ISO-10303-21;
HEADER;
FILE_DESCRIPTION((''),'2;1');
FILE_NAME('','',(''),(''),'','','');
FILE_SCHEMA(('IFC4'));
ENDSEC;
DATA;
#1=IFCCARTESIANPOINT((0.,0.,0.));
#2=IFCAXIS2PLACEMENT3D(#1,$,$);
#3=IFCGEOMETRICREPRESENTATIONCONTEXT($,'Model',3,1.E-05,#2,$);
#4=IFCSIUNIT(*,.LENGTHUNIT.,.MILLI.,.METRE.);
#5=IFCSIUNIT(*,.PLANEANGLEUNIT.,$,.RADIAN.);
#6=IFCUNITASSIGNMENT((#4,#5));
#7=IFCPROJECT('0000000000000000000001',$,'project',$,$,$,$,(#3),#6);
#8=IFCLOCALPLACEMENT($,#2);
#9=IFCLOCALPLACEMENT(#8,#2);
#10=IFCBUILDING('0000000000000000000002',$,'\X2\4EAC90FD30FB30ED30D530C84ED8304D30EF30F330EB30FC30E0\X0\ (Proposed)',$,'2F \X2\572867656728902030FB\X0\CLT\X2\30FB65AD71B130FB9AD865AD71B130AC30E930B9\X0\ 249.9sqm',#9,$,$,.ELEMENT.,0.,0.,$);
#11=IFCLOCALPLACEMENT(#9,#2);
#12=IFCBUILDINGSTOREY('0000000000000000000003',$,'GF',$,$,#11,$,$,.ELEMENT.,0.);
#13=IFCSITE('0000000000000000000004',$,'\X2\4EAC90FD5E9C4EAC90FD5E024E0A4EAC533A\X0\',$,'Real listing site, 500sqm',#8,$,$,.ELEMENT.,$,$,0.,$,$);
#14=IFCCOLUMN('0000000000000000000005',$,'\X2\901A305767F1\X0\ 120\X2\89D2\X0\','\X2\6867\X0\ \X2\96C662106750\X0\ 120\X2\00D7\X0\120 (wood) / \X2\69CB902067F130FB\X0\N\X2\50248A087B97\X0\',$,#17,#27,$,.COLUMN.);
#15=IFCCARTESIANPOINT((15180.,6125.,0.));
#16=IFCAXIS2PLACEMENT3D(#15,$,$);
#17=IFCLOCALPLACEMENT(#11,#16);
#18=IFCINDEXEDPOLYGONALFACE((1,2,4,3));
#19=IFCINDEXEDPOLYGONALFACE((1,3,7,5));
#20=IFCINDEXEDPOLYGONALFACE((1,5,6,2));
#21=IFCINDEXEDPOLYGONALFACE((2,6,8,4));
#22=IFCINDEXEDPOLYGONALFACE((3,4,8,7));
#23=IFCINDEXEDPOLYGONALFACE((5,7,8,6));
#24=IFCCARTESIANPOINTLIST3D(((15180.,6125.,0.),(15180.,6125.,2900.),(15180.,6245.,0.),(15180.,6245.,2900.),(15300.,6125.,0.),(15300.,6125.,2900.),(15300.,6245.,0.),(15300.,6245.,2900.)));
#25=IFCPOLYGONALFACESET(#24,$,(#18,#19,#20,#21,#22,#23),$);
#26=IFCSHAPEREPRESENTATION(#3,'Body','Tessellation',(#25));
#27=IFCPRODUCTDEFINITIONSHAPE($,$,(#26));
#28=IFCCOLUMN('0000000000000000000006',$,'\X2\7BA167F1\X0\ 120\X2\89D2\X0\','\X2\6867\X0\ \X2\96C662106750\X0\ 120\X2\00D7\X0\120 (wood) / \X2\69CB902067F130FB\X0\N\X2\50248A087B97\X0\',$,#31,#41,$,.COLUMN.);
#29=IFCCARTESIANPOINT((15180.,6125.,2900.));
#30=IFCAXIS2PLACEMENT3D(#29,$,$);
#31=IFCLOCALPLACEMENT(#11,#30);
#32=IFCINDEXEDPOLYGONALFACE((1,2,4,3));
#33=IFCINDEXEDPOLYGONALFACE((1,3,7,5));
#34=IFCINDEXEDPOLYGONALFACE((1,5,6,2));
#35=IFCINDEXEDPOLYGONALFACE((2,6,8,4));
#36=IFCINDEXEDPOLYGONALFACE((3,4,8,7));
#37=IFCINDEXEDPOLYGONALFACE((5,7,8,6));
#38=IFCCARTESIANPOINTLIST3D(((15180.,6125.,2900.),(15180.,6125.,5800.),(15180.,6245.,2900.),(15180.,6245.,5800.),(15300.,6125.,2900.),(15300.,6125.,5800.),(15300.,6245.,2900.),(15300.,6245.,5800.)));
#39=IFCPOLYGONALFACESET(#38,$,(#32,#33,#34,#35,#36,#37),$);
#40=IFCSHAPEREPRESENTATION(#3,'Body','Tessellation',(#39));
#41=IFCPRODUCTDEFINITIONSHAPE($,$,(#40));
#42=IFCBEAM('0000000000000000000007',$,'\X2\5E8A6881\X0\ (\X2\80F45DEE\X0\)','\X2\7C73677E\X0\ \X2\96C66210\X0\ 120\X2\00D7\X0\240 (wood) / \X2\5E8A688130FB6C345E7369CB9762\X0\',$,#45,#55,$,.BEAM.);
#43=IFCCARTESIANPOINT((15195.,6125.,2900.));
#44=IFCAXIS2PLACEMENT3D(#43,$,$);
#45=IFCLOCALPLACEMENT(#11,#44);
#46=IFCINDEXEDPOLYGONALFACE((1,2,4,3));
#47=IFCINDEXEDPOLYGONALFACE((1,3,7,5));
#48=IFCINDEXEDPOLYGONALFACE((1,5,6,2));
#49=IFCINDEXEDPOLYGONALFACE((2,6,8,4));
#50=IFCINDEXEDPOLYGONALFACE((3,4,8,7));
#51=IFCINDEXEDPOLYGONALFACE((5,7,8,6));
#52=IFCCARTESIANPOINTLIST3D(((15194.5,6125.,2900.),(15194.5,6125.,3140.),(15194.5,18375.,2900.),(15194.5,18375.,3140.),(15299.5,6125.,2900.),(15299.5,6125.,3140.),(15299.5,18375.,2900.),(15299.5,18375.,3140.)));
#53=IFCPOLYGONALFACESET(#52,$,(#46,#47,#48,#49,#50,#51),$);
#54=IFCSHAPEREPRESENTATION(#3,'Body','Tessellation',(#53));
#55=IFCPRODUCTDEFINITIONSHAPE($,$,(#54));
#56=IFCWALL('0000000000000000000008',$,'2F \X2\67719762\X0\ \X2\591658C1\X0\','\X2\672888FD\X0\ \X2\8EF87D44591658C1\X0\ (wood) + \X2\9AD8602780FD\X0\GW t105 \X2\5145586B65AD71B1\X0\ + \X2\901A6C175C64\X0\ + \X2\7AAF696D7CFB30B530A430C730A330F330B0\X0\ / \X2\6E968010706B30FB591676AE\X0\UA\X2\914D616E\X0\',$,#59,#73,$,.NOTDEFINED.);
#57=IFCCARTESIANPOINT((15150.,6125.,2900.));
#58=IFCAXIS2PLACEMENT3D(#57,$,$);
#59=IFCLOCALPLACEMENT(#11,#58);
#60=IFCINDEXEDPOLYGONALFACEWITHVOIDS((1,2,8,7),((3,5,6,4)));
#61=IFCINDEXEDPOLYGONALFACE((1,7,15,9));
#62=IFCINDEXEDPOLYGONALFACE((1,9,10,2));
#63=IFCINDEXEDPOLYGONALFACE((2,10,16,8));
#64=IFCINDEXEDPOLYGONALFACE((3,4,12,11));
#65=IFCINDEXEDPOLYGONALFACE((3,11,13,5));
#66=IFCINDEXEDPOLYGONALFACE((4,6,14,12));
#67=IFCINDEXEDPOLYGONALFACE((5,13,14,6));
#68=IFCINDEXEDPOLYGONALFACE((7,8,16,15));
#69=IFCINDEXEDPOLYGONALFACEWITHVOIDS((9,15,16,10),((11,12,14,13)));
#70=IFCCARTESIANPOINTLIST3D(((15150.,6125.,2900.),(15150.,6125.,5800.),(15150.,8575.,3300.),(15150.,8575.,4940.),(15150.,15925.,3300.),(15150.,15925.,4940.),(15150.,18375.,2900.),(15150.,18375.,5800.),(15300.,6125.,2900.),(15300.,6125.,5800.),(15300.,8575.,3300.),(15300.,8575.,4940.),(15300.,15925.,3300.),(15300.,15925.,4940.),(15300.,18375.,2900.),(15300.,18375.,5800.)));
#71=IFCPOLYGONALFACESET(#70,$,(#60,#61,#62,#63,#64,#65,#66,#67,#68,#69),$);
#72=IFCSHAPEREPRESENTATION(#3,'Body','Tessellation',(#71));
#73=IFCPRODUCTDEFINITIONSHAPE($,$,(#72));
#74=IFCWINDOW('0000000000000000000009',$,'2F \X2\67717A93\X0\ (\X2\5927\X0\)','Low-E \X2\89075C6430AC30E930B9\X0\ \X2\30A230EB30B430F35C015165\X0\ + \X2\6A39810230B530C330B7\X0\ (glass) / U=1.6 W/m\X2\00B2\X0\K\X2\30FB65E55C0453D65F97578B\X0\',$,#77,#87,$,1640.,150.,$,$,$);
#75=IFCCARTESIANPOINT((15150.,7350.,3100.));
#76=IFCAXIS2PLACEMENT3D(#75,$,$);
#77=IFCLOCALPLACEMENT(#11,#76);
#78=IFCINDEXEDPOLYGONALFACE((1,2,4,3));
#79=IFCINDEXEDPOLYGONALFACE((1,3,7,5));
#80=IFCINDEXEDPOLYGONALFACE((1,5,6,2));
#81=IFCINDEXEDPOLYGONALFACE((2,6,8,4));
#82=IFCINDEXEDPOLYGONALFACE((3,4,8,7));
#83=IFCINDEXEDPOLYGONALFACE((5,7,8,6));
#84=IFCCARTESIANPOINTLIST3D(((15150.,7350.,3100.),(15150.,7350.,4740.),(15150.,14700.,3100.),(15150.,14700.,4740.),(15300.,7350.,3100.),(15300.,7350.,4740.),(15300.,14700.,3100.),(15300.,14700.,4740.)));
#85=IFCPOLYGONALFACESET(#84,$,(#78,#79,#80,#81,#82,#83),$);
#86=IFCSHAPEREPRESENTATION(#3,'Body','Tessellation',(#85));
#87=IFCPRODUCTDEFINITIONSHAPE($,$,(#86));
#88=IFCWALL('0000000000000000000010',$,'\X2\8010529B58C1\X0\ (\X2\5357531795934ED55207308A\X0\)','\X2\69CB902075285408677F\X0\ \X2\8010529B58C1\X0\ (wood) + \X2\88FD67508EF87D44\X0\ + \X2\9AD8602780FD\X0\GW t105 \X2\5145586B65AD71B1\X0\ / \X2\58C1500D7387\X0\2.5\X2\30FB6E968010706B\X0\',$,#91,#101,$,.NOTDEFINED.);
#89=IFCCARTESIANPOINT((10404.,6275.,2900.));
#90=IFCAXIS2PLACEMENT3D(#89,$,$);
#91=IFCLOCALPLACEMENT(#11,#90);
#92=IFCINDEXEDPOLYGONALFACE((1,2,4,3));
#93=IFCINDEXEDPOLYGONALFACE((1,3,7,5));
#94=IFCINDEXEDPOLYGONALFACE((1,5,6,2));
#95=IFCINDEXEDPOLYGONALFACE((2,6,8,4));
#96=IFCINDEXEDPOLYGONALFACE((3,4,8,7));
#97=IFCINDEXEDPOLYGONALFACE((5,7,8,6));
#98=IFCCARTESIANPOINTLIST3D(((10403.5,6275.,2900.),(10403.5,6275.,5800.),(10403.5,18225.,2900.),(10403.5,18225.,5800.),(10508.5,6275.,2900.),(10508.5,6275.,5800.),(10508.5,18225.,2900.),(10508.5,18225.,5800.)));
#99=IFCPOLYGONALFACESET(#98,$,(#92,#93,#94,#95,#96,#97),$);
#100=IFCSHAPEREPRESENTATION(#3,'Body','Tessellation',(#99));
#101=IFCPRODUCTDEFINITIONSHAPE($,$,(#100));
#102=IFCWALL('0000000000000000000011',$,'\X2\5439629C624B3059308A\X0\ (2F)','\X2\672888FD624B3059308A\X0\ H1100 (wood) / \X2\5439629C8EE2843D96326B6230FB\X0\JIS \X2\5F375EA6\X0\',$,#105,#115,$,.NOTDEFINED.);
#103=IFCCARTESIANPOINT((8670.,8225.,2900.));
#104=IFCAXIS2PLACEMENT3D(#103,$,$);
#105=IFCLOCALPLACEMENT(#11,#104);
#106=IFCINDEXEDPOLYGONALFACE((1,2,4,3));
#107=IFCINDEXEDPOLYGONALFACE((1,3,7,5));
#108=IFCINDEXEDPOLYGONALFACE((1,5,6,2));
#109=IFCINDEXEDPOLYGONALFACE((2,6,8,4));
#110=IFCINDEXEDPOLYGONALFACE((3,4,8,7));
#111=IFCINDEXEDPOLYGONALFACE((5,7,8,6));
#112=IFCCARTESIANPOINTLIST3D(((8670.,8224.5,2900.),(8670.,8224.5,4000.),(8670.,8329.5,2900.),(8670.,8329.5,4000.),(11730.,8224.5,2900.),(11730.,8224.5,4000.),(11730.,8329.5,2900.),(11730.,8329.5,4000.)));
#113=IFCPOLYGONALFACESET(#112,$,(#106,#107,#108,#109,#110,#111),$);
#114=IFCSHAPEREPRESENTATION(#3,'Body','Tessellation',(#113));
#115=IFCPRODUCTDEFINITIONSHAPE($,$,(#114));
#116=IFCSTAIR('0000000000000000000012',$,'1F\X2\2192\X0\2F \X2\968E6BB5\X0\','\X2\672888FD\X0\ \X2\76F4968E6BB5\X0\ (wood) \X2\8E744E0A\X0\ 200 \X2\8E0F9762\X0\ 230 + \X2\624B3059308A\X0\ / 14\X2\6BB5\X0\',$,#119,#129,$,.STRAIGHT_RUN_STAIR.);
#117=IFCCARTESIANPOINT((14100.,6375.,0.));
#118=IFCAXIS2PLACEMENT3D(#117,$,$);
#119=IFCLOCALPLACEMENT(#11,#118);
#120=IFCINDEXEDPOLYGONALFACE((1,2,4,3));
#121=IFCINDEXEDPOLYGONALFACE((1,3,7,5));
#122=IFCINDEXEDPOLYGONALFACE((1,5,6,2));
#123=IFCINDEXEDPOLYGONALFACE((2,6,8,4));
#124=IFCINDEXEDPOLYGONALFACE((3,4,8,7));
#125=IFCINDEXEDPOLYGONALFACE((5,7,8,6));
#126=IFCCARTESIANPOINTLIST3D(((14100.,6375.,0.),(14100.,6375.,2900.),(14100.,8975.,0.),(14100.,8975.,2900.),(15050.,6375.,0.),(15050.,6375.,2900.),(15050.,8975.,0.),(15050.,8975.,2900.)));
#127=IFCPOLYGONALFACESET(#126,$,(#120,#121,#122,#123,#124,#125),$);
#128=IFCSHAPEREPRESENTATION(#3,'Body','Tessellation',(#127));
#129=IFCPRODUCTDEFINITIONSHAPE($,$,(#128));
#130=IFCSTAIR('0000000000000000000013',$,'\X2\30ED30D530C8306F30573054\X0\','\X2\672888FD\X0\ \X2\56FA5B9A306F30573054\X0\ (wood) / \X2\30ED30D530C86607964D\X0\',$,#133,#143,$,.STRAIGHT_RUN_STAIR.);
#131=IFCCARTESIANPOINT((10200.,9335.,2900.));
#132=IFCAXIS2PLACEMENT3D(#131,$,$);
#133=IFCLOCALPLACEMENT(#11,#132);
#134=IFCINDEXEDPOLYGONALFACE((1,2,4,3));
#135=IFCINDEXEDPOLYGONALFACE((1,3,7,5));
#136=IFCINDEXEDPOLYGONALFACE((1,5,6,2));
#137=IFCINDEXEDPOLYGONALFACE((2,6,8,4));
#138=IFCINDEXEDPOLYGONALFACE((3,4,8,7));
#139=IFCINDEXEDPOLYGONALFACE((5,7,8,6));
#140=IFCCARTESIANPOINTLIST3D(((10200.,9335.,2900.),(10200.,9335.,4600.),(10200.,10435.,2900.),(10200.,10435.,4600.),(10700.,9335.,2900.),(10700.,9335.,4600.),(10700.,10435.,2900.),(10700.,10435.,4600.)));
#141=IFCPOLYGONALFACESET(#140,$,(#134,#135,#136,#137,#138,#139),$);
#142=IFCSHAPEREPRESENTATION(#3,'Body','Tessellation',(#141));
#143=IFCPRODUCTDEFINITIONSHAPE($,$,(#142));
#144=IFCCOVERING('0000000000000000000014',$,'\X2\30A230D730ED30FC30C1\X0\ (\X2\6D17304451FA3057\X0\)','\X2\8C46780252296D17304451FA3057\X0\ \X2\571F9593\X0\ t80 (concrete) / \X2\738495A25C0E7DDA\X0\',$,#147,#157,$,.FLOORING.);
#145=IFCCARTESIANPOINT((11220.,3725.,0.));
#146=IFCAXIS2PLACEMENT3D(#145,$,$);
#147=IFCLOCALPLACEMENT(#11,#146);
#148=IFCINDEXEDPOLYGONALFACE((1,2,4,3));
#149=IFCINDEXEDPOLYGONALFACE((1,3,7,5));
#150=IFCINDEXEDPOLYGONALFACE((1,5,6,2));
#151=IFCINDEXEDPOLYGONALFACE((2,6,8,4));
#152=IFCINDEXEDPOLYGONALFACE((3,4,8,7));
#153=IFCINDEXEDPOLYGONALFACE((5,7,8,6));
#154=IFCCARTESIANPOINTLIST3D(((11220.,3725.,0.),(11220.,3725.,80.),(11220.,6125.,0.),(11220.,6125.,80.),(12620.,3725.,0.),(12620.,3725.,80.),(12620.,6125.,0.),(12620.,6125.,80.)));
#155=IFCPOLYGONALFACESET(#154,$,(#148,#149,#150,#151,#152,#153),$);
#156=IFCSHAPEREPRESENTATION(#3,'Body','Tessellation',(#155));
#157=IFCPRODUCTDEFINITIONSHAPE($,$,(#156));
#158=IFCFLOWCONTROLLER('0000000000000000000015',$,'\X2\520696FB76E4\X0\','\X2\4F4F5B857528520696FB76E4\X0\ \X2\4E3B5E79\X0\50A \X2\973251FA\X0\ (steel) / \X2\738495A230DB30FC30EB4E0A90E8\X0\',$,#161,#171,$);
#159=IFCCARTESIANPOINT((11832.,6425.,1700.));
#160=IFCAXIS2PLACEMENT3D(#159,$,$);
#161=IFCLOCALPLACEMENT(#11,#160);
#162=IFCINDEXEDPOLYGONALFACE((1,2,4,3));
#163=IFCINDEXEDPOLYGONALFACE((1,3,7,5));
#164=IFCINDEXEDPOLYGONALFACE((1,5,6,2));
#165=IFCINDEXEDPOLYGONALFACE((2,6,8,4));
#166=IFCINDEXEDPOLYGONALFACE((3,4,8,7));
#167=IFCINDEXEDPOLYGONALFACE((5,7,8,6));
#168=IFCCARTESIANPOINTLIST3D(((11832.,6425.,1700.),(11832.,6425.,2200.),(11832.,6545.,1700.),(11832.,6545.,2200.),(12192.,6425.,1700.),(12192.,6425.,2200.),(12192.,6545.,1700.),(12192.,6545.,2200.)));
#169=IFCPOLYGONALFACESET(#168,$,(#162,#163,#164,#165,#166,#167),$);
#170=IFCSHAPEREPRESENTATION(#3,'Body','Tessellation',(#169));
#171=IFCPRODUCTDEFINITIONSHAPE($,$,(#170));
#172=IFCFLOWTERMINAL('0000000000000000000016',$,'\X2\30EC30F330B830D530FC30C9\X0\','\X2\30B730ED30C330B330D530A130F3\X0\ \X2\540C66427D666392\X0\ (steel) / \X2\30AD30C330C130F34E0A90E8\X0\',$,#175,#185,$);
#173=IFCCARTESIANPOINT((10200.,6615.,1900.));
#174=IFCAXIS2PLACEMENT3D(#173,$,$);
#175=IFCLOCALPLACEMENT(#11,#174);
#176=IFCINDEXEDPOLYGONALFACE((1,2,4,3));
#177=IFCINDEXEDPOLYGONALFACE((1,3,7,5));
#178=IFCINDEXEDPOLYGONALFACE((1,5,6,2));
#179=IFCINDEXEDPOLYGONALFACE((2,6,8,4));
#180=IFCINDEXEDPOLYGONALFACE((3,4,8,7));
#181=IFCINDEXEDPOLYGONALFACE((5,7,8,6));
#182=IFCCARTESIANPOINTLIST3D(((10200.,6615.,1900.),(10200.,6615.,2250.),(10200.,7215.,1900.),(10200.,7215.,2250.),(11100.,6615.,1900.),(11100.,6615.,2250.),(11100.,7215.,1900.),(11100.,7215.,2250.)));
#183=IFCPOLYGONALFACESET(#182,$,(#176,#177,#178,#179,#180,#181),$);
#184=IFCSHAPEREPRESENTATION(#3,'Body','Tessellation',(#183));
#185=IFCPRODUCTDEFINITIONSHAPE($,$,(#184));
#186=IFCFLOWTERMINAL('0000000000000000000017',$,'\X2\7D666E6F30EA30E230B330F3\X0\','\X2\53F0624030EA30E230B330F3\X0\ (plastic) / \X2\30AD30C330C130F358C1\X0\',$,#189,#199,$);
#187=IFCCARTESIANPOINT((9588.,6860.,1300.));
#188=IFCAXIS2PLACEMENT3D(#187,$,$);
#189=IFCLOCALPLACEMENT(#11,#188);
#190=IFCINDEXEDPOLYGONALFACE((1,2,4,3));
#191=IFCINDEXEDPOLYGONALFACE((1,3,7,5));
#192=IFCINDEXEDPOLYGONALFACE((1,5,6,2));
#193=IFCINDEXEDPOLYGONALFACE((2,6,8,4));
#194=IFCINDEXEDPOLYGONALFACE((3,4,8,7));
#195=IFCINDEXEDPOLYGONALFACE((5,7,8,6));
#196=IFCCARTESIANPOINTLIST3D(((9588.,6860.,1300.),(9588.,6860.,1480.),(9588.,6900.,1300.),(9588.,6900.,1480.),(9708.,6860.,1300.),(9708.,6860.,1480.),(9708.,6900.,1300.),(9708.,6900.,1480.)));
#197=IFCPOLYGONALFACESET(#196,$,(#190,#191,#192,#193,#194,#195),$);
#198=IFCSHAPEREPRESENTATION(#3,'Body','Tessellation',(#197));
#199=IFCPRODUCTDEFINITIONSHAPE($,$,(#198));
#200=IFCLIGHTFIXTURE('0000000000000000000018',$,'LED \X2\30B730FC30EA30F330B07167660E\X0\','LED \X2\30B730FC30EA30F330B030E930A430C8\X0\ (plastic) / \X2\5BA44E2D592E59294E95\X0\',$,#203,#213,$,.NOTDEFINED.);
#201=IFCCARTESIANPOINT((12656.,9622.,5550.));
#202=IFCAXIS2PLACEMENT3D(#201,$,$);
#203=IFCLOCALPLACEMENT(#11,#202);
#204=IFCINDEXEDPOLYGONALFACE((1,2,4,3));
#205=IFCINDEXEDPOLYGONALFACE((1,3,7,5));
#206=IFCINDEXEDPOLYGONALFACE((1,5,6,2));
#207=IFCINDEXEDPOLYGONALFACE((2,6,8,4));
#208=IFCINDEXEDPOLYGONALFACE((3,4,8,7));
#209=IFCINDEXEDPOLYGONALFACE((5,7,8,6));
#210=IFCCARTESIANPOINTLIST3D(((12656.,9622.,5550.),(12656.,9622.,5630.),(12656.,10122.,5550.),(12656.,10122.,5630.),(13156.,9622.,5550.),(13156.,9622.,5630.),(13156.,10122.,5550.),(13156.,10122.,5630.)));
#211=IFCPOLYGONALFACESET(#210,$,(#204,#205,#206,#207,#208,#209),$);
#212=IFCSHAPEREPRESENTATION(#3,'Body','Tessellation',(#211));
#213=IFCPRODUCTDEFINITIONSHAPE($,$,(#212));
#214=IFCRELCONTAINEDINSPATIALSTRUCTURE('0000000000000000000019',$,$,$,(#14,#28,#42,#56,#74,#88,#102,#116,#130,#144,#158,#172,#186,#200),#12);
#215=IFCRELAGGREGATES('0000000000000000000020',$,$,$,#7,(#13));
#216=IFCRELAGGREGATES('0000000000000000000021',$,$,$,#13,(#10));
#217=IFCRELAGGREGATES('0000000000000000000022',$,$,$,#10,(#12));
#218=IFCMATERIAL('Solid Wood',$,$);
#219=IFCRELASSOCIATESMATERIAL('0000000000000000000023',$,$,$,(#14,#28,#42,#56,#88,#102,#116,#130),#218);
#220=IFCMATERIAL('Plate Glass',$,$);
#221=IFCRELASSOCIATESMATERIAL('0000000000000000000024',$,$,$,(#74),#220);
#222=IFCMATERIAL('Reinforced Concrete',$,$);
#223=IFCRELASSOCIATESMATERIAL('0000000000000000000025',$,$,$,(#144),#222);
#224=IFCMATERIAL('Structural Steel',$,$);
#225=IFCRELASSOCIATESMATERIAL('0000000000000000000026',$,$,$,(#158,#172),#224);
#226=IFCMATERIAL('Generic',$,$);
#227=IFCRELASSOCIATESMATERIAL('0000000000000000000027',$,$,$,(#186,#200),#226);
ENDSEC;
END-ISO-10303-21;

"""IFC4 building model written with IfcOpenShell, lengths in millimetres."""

from ifc_helpers import new_model, si_unit, frame, frame_2d, origin, place, context, project, spatial, rectangle, extrude, material, element, fill, save


model = new_model("IFC4")

# Units and contexts
model_context = context("Model", 3, precision=1e-05, world=origin())
ifc_project = project(units=[si_unit("LENGTHUNIT", "METRE", prefix="MILLI"), si_unit("PLANEANGLEUNIT", "RADIAN")], contexts=[model_context])

# Site, building, storey
site_placement = place(None, origin())
site = spatial("IfcSite", under=ifc_project, at=site_placement, Name="京都府京都市上京区", ObjectType="Real listing site, 500sqm", CompositionType="ELEMENT", RefElevation=0.0)
building_placement = place(site_placement, origin())
building = spatial("IfcBuilding", under=site, at=building_placement, Name="京都・ロフト付きワンルーム (Proposed)", ObjectType="2F 在来木造・CLT・断熱・高断熱ガラス 249.9sqm", CompositionType="ELEMENT", ElevationOfRefHeight=0.0, ElevationOfTerrain=0.0)
storey_placement = place(building_placement, origin())
storey = spatial("IfcBuildingStorey", under=building, at=storey_placement, Name="GF", CompositionType="ELEMENT", Elevation=0.0)

# Columns
ifc_material_1 = material(Name="Solid Wood")
column_1_placement = place(storey_placement, frame((15180.0, 6125.0, 0.0)))
element("IfcColumn", 1, at=column_1_placement, inside=storey, material=ifc_material_1, Name="通し柱 120角", Description="桧 集成材 120×120 (wood) / 構造柱・N値計算", PredefinedType="COLUMN", context=model_context, shape_type="SweptSolid", body=[
    extrude(rectangle(XDim=120.0, YDim=120.0, at=frame_2d((60.0, 60.0))), frame((15180.0, 6125.0, 0.0)), (0.0, 0.0, 1.0), 2900.0),
])
column_2_placement = place(storey_placement, frame((15180.0, 6125.0, 2900.0)))
element("IfcColumn", 2, at=column_2_placement, inside=storey, material=ifc_material_1, Name="管柱 120角", Description="桧 集成材 120×120 (wood) / 構造柱・N値計算", PredefinedType="COLUMN", context=model_context, shape_type="SweptSolid", body=[
    extrude(rectangle(XDim=120.0, YDim=120.0, at=frame_2d((60.0, 60.0))), frame((15180.0, 6125.0, 2900.0)), (0.0, 0.0, 1.0), 2900.0),
])

# Beam
beam_1_placement = place(storey_placement, frame((15195.0, 6125.0, 2900.0)))
element("IfcBeam", 3, at=beam_1_placement, inside=storey, material=ifc_material_1, Name="床梁 (胴差)", Description="米松 集成 120×240 (wood) / 床梁・水平構面", PredefinedType="BEAM", context=model_context, shape_type="SweptSolid", body=[
    extrude(rectangle(XDim=105.0, YDim=12250.0, at=frame_2d((52.0, 6125.0))), frame((15195.0, 6125.0, 2900.0)), (0.0, 0.0, 1.0), 240.0),
])

# Shared definitions
ifc_material_2 = material(Name="Plate Glass")

# Wall, opening, window
wall_1_placement = place(storey_placement, frame((15150.0, 6125.0, 2900.0)))
wall_1 = element("IfcWall", 4, at=wall_1_placement, inside=storey, material=ifc_material_1, Name="2F 東面 外壁", Description="木製 軸組外壁 (wood) + 高性能GW t105 充填断熱 + 通気層 + 窯業系サイディング / 準耐火・外皮UA配慮", PredefinedType="NOTDEFINED", context=model_context, shape_type="SweptSolid", body=[
    extrude(rectangle(XDim=150.0, YDim=12250.0, at=frame_2d((75.0, 6125.0))), frame((15150.0, 6125.0, 2900.0)), (0.0, 0.0, 1.0), 2900.0),
])
opening_1_placement = place(storey_placement, frame((15150.0, 7350.0, 3100.0)))
opening_1 = element("IfcOpeningElement", 5, at=opening_1_placement, cuts=wall_1, PredefinedType="NOTDEFINED", context=model_context, shape_type="SweptSolid", body=[
    extrude(rectangle(XDim=150.0, YDim=7350.0, at=frame_2d((75.0, 3675.0))), frame((15150.0, 7350.0, 3100.0)), (0.0, 0.0, 1.0), 1640.0),
])
window_1_placement = place(storey_placement, frame((15150.0, 7350.0, 3100.0)))
window_1 = element("IfcWindow", 6, at=window_1_placement, inside=storey, material=ifc_material_2, Name="2F 東窓 (大)", Description="Low-E 複層ガラス アルゴン封入 + 樹脂サッシ (glass) / U=1.6 W/m²K・日射取得型", OverallHeight=1640.0, OverallWidth=150.0, context=model_context, shape_type="SweptSolid", body=[
    extrude(rectangle(XDim=150.0, YDim=7350.0, at=frame_2d((75.0, 3675.0))), frame((15150.0, 7350.0, 3100.0)), (0.0, 0.0, 1.0), 1640.0),
])
fill(opening_1, window_1)

# Walls
wall_2_placement = place(storey_placement, frame((10404.0, 6275.0, 2900.0)))
element("IfcWall", 7, at=wall_2_placement, inside=storey, material=ifc_material_1, Name="耐力壁 (南北間仕切り)", Description="構造用合板 耐力壁 (wood) + 製材軸組 + 高性能GW t105 充填断熱 / 壁倍率2.5・準耐火", PredefinedType="NOTDEFINED", context=model_context, shape_type="SweptSolid", body=[
    extrude(rectangle(XDim=105.0, YDim=11950.0, at=frame_2d((52.0, 5975.0))), frame((10404.0, 6275.0, 2900.0)), (0.0, 0.0, 1.0), 2900.0),
])
wall_3_placement = place(storey_placement, frame((8670.0, 8225.0, 2900.0)))
element("IfcWall", 8, at=wall_3_placement, inside=storey, material=ifc_material_1, Name="吹抜手すり (2F)", Description="木製手すり H1100 (wood) / 吹抜転落防止・JIS 強度", PredefinedType="NOTDEFINED", context=model_context, shape_type="SweptSolid", body=[
    extrude(rectangle(XDim=3060.0, YDim=105.0, at=frame_2d((1530.0, 52.0))), frame((8670.0, 8225.0, 2900.0)), (0.0, 0.0, 1.0), 1100.0),
])

# Stairs
stair_1_placement = place(storey_placement, frame((14100.0, 6375.0, 0.0)))
element("IfcStair", 9, at=stair_1_placement, inside=storey, material=ifc_material_1, Name="1F→2F 階段", Description="木製 直階段 (wood) 蹴上 200 踏面 230 + 手すり / 14段", PredefinedType="STRAIGHT_RUN_STAIR", context=model_context, shape_type="SweptSolid", body=[
    extrude(rectangle(XDim=950.0, YDim=2600.0, at=frame_2d((475.0, 1300.0))), frame((14100.0, 6375.0, 0.0)), (0.0, 0.0, 1.0), 2900.0),
])
stair_2_placement = place(storey_placement, frame((10200.0, 9335.0, 2900.0)))
element("IfcStair", 10, at=stair_2_placement, inside=storey, material=ifc_material_1, Name="ロフトはしご", Description="木製 固定はしご (wood) / ロフト昇降", PredefinedType="STRAIGHT_RUN_STAIR", context=model_context, shape_type="SweptSolid", body=[
    extrude(rectangle(XDim=500.0, YDim=1100.0, at=frame_2d((250.0, 550.0))), frame((10200.0, 9335.0, 2900.0)), (0.0, 0.0, 1.0), 1700.0),
])

# Covering
ifc_material_3 = material(Name="Reinforced Concrete")
covering_placement = place(storey_placement, frame((11220.0, 3725.0, 0.0)))
element("IfcCovering", 11, at=covering_placement, inside=storey, material=ifc_material_3, Name="アプローチ (洗い出し)", Description="豆砂利洗い出し 土間 t80 (concrete) / 玄関導線", PredefinedType="FLOORING", context=model_context, shape_type="SweptSolid", body=[
    extrude(rectangle(XDim=1400.0, YDim=2400.0, at=frame_2d((700.0, 1200.0))), frame((11220.0, 3725.0, 0.0)), (0.0, 0.0, 1.0), 80.0),
])

# Flow controller
ifc_material_4 = material(Name="Structural Steel")
flow_controller_placement = place(storey_placement, frame((11832.0, 6425.0, 1700.0)))
element("IfcFlowController", 12, at=flow_controller_placement, inside=storey, material=ifc_material_4, Name="分電盤", Description="住宅用分電盤 主幹50A 露出 (steel) / 玄関ホール上部", context=model_context, shape_type="SweptSolid", body=[
    extrude(rectangle(XDim=360.0, YDim=120.0, at=frame_2d((180.0, 60.0))), frame((11832.0, 6425.0, 1700.0)), (0.0, 0.0, 1.0), 500.0),
])

# Flow terminals
flow_terminal_1_placement = place(storey_placement, frame((10200.0, 6615.0, 1900.0)))
element("IfcFlowTerminal", 13, at=flow_terminal_1_placement, inside=storey, material=ifc_material_4, Name="レンジフード", Description="シロッコファン 同時給排 (steel) / キッチン上部", context=model_context, shape_type="SweptSolid", body=[
    extrude(rectangle(XDim=900.0, YDim=600.0, at=frame_2d((450.0, 300.0))), frame((10200.0, 6615.0, 1900.0)), (0.0, 0.0, 1.0), 350.0),
])
ifc_material_5 = material(Name="Generic")
flow_terminal_2_placement = place(storey_placement, frame((9588.0, 6860.0, 1300.0)))
element("IfcFlowTerminal", 14, at=flow_terminal_2_placement, inside=storey, material=ifc_material_5, Name="給湯リモコン", Description="台所リモコン (plastic) / キッチン壁", context=model_context, shape_type="SweptSolid", body=[
    extrude(rectangle(XDim=120.0, YDim=40.0, at=frame_2d((60.0, 20.0))), frame((9588.0, 6860.0, 1300.0)), (0.0, 0.0, 1.0), 180.0),
])

# Light fixture
light_fixture_placement = place(storey_placement, frame((12656.0, 9622.0, 5550.0)))
element("IfcLightFixture", 15, at=light_fixture_placement, inside=storey, material=ifc_material_5, Name="LED シーリング照明", Description="LED シーリングライト (plastic) / 室中央天井", PredefinedType="NOTDEFINED", context=model_context, shape_type="SweptSolid", body=[
    extrude(rectangle(XDim=500.0, YDim=500.0, at=frame_2d((250.0, 250.0))), frame((12656.0, 9622.0, 5550.0)), (0.0, 0.0, 1.0), 80.0),
])

save(model, "model.ifc")
